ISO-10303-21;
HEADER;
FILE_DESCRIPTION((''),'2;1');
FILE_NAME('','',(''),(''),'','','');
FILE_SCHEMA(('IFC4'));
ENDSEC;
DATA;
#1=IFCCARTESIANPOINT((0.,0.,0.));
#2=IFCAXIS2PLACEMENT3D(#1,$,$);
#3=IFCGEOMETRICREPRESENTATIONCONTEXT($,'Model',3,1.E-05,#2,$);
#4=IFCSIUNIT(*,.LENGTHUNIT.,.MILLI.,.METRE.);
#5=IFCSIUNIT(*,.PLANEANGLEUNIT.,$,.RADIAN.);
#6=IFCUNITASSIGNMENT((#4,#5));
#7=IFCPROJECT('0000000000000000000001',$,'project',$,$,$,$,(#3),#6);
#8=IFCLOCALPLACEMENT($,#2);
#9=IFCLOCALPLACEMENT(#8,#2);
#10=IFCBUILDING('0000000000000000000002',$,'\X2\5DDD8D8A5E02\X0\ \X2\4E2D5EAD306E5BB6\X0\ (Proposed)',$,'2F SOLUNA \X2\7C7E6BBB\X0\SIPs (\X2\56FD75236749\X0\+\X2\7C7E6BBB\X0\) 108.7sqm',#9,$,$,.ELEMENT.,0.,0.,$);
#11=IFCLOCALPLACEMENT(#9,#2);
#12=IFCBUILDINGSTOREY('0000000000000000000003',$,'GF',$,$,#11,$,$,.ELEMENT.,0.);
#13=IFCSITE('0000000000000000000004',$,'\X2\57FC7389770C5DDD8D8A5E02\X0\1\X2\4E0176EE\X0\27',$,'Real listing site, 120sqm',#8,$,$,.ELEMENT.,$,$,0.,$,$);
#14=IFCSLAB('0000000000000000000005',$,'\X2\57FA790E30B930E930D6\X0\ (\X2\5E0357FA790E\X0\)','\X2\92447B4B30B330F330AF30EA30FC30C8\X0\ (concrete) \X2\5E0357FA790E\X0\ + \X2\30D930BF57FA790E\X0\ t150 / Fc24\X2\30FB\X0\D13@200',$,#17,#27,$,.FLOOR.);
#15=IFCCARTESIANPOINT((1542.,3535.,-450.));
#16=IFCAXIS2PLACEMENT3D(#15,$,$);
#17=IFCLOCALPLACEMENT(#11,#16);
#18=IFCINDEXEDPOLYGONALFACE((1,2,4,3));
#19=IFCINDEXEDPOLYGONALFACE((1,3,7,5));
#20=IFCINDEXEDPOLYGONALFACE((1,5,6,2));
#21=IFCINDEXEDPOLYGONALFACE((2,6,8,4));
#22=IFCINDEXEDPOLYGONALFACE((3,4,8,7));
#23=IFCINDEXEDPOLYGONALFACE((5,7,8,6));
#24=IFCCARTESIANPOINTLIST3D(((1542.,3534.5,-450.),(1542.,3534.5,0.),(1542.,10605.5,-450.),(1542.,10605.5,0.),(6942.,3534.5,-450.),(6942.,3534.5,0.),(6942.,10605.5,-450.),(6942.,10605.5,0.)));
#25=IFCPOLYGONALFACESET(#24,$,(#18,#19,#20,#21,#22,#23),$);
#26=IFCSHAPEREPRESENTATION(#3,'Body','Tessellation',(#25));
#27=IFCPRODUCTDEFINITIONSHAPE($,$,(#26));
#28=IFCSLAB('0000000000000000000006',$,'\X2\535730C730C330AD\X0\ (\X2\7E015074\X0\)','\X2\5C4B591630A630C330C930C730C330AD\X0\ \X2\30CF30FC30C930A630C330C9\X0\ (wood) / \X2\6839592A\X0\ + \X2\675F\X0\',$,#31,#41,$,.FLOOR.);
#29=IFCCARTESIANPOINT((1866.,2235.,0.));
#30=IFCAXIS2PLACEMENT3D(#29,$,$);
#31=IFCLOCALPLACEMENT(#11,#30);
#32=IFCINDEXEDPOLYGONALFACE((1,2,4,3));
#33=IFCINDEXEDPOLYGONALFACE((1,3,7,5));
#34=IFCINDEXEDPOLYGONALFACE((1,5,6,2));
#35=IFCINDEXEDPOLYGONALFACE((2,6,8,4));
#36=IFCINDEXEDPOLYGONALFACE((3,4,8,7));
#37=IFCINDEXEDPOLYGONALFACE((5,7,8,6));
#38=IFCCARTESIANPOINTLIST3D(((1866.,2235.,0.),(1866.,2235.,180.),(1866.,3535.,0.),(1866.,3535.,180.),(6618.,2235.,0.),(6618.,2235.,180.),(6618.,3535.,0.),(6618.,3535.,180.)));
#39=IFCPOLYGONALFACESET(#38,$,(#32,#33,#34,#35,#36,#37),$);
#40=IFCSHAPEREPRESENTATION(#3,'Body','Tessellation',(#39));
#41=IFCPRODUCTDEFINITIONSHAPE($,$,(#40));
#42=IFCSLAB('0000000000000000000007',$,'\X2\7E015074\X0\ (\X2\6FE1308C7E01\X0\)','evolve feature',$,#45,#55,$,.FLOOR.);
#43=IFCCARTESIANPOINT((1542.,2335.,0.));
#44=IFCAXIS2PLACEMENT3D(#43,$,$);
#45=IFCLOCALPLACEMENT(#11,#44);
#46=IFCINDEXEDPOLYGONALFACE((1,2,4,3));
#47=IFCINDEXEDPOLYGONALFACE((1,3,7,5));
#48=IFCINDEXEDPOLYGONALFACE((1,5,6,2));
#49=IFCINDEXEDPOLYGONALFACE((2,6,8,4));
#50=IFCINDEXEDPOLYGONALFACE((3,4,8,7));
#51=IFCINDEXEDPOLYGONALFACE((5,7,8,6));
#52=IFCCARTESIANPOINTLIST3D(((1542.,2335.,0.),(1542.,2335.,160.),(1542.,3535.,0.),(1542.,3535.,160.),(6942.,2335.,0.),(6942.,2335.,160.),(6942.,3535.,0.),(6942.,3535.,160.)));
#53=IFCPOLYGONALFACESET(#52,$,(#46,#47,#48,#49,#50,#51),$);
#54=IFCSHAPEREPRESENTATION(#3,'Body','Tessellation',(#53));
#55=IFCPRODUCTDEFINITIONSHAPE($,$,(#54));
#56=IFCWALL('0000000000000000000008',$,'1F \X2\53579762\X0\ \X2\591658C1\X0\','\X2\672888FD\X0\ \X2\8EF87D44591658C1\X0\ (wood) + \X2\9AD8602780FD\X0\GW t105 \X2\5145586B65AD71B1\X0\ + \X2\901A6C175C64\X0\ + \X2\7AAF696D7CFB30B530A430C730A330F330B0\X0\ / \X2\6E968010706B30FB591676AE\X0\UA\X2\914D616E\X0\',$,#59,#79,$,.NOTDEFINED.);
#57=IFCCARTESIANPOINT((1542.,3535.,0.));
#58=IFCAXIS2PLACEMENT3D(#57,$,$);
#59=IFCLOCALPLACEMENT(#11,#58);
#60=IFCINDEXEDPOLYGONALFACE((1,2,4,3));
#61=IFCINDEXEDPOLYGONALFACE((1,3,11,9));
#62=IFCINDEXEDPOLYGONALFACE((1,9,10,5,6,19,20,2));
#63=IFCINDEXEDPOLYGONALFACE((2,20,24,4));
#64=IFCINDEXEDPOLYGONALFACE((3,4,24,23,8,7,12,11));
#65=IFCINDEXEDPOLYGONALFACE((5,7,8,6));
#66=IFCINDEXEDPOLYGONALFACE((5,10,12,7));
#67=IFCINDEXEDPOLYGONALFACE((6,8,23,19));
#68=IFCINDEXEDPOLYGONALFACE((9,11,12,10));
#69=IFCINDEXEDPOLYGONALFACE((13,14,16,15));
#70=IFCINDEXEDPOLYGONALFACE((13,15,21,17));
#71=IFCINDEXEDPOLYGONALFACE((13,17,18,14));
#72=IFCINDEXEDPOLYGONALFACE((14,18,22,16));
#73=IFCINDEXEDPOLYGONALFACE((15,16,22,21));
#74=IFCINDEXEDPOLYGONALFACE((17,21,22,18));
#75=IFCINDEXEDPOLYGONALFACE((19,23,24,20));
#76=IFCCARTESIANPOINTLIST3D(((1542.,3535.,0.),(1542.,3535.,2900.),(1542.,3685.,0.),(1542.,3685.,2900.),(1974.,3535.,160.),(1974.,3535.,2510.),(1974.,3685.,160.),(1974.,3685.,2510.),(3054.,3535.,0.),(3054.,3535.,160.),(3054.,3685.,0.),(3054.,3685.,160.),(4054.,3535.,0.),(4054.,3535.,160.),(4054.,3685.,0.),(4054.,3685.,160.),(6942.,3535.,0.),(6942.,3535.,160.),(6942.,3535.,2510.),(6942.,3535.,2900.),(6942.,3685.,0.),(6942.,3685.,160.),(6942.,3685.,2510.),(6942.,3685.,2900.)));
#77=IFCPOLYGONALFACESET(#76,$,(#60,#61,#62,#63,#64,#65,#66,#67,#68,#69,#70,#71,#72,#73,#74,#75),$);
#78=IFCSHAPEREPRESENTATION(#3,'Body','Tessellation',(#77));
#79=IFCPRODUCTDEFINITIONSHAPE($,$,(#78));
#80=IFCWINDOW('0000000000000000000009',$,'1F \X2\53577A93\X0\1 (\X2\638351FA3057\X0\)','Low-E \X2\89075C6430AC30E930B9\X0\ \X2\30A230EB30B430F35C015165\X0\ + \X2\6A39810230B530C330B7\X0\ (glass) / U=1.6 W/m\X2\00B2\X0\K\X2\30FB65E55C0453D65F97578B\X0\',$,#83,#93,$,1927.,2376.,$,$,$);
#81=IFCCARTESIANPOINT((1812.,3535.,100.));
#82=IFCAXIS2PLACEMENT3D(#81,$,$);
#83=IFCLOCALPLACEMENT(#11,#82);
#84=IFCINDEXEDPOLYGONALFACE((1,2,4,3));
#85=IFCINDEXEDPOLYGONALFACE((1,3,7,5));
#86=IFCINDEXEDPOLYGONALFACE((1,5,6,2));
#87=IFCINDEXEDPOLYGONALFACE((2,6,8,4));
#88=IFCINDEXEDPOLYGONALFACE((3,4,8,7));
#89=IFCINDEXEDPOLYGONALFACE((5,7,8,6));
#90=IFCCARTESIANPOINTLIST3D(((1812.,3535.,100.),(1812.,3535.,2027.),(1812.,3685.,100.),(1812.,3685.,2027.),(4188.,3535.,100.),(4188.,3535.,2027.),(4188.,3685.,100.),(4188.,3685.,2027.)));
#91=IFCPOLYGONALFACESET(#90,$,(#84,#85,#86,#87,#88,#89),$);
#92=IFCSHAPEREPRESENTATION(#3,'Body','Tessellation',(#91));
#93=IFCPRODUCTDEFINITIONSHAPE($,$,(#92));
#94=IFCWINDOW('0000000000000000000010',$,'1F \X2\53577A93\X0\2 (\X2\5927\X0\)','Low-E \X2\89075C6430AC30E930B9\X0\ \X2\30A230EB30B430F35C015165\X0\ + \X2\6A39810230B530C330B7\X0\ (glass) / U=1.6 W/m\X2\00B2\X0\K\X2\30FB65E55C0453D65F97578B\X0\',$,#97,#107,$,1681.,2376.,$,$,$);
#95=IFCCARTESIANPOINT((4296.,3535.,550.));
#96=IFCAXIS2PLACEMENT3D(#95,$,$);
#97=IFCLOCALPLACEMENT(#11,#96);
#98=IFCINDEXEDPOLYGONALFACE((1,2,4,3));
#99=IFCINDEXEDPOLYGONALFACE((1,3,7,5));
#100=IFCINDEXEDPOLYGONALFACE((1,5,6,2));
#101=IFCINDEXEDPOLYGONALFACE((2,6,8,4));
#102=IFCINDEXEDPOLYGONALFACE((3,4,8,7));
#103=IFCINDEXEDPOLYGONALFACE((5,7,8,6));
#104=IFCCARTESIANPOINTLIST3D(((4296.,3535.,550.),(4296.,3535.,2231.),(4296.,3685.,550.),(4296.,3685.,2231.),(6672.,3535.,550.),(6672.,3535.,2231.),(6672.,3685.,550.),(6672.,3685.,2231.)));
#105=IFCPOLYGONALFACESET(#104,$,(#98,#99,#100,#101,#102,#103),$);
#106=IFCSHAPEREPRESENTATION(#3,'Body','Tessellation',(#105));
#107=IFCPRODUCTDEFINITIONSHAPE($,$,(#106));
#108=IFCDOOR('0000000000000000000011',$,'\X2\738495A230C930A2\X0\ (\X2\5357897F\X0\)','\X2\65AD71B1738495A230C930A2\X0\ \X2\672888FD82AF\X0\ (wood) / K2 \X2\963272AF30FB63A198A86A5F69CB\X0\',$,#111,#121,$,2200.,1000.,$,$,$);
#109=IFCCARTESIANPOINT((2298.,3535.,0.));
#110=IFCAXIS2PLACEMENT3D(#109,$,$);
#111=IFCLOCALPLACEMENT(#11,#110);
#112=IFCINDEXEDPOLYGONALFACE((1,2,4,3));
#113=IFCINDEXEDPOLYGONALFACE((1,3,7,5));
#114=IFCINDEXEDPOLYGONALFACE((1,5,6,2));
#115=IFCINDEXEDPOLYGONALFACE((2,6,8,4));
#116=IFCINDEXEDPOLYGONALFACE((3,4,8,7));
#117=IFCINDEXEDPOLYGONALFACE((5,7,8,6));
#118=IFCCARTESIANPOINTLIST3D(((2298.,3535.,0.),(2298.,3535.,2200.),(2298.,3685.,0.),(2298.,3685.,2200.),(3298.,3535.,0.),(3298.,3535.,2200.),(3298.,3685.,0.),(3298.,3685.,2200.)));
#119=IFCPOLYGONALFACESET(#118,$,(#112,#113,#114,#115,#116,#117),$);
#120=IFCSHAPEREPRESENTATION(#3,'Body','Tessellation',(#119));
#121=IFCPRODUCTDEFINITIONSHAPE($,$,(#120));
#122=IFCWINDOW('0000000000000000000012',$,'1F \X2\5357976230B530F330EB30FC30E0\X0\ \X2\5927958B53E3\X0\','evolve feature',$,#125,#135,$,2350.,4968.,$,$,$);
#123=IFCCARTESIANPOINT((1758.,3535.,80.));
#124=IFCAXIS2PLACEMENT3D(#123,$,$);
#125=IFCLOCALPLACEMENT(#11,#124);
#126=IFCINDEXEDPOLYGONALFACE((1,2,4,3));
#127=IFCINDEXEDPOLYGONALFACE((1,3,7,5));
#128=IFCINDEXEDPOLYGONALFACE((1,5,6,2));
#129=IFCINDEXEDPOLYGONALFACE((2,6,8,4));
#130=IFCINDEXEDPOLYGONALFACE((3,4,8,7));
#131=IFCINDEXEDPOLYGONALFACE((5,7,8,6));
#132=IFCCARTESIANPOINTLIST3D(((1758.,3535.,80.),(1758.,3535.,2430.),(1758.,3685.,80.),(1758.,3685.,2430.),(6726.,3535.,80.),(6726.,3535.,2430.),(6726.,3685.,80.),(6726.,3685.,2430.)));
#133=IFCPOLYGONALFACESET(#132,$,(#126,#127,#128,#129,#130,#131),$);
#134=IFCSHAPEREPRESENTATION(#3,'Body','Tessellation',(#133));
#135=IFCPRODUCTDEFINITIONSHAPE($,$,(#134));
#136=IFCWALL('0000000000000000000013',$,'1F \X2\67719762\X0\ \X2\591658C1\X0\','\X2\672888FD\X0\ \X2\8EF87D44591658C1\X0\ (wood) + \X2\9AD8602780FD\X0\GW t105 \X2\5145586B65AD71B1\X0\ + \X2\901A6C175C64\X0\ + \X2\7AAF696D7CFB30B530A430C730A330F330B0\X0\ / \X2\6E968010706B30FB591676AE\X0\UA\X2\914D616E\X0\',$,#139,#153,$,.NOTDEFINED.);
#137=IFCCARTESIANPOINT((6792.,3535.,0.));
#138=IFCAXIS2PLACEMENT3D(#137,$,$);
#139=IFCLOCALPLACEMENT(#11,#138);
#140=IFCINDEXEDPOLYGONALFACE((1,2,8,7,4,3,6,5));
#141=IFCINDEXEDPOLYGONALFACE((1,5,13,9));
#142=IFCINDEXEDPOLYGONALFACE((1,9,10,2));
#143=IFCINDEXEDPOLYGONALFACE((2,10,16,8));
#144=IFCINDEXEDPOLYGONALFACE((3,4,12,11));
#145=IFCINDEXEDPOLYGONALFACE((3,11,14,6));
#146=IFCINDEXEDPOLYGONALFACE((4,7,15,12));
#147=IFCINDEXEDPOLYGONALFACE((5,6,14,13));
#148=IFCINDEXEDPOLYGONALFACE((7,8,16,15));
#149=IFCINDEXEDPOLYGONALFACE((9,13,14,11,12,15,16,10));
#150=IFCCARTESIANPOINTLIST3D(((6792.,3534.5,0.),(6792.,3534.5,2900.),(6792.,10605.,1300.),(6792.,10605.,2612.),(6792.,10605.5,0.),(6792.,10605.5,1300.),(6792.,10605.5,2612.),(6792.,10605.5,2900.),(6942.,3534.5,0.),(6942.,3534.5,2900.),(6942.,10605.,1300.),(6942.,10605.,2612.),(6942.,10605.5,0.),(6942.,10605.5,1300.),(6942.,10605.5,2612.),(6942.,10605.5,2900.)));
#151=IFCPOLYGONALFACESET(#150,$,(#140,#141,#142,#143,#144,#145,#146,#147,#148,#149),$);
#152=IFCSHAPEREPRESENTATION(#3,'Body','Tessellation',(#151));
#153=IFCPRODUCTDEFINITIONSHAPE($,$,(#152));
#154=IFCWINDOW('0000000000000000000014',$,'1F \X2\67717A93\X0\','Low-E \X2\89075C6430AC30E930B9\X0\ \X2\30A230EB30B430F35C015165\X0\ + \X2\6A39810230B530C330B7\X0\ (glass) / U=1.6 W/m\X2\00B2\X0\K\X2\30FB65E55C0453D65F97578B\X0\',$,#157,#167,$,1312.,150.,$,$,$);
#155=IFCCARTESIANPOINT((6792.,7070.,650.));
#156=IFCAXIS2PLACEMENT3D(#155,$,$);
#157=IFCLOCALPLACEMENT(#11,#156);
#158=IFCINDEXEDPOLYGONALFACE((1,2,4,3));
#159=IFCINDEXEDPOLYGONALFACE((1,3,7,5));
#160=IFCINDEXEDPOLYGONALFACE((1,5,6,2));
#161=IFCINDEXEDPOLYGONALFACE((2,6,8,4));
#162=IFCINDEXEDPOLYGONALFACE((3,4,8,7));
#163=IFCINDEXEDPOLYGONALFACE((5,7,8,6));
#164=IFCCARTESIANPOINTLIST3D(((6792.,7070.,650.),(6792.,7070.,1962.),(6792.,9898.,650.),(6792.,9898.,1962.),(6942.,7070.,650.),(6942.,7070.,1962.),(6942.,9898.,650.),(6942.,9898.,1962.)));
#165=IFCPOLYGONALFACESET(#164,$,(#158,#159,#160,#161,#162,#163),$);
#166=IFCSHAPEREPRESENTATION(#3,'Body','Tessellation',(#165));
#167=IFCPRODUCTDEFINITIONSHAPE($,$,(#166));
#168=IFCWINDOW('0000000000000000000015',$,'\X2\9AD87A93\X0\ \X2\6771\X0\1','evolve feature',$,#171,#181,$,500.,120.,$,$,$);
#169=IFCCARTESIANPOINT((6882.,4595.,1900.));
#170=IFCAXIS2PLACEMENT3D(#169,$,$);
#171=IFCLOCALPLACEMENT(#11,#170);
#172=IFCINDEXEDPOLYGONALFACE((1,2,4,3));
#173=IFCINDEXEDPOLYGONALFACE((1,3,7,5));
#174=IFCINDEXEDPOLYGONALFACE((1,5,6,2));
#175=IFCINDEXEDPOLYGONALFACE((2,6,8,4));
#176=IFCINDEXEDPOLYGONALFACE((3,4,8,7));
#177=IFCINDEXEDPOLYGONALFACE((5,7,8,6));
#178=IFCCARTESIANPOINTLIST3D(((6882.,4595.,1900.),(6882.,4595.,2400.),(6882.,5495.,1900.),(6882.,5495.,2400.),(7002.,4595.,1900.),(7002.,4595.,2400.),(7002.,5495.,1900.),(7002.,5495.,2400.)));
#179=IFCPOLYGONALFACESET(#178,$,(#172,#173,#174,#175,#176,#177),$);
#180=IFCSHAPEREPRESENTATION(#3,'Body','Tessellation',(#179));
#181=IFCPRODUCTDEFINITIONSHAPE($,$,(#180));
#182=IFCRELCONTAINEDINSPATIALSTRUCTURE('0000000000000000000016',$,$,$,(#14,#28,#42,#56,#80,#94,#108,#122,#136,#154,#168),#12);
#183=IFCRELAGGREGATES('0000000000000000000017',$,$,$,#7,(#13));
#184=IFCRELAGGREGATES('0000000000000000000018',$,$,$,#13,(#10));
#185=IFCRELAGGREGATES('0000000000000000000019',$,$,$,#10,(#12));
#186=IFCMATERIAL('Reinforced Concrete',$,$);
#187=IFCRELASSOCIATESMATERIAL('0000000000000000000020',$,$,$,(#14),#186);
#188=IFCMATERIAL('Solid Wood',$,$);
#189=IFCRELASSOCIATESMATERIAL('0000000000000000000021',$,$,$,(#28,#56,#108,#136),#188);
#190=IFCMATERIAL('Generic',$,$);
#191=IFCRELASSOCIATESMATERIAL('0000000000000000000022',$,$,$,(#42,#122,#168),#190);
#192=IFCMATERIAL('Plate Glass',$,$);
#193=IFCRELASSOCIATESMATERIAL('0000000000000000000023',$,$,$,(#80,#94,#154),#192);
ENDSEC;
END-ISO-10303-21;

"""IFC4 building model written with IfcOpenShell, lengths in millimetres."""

from ifc_helpers import new_model, si_unit, frame, frame_2d, origin, place, context, project, spatial, rectangle, extrude, material, element, fill, save


model = new_model("IFC4")

# Units and contexts
model_context = context("Model", 3, precision=1e-05, world=origin())
ifc_project = project(units=[si_unit("LENGTHUNIT", "METRE", prefix="MILLI"), si_unit("PLANEANGLEUNIT", "RADIAN")], contexts=[model_context])

# Site, building, storey
site_placement = place(None, origin())
site = spatial("IfcSite", under=ifc_project, at=site_placement, Name="埼玉県川越市1丁目27", ObjectType="Real listing site, 120sqm", CompositionType="ELEMENT", RefElevation=0.0)
building_placement = place(site_placement, origin())
building = spatial("IfcBuilding", under=site, at=building_placement, Name="川越市 中庭の家 (Proposed)", ObjectType="2F SOLUNA 籾殻SIPs (国産杉+籾殻) 108.7sqm", CompositionType="ELEMENT", ElevationOfRefHeight=0.0, ElevationOfTerrain=0.0)
storey_placement = place(building_placement, origin())
storey = spatial("IfcBuildingStorey", under=building, at=storey_placement, Name="GF", CompositionType="ELEMENT", Elevation=0.0)

# Slabs
ifc_material_1 = material(Name="Reinforced Concrete")
slab_1_placement = place(storey_placement, frame((1542.0, 3535.0, -450.0)))
element("IfcSlab", 1, at=slab_1_placement, inside=storey, material=ifc_material_1, Name="基礎スラブ (布基礎)", Description="鉄筋コンクリート (concrete) 布基礎 + ベタ基礎 t150 / Fc24・D13@200", PredefinedType="FLOOR", context=model_context, shape_type="SweptSolid", body=[
    extrude(rectangle(XDim=5400.0, YDim=7071.0, at=frame_2d((2700.0, 3535.0))), frame((1542.0, 3535.0, -450.0)), (0.0, 0.0, 1.0), 450.0),
])
ifc_material_2 = material(Name="Solid Wood")
slab_2_placement = place(storey_placement, frame((1866.0, 2235.0, 0.0)))
element("IfcSlab", 2, at=slab_2_placement, inside=storey, material=ifc_material_2, Name="南デッキ (縁側)", Description="屋外ウッドデッキ ハードウッド (wood) / 根太 + 束", PredefinedType="FLOOR", context=model_context, shape_type="SweptSolid", body=[
    extrude(rectangle(XDim=4752.0, YDim=1300.0, at=frame_2d((2376.0, 650.0))), frame((1866.0, 2235.0, 0.0)), (0.0, 0.0, 1.0), 180.0),
])
ifc_material_3 = material(Name="Generic")
slab_3_placement = place(storey_placement, frame((1542.0, 2335.0, 0.0)))
element("IfcSlab", 3, at=slab_3_placement, inside=storey, material=ifc_material_3, Name="縁側 (濡れ縁)", Description="evolve feature", PredefinedType="FLOOR", context=model_context, shape_type="SweptSolid", body=[
    extrude(rectangle(XDim=5400.0, YDim=1200.0, at=frame_2d((2700.0, 600.0))), frame((1542.0, 2335.0, 0.0)), (0.0, 0.0, 1.0), 160.0),
])

# Wall, openings, windows, door
wall_1_placement = place(storey_placement, frame((1542.0, 3535.0, 0.0)))
wall_1 = element("IfcWall", 4, at=wall_1_placement, inside=storey, material=ifc_material_2, Name="1F 南面 外壁", Description="木製 軸組外壁 (wood) + 高性能GW t105 充填断熱 + 通気層 + 窯業系サイディング / 準耐火・外皮UA配慮", PredefinedType="NOTDEFINED", context=model_context, shape_type="SweptSolid", body=[
    extrude(rectangle(XDim=5400.0, YDim=150.0, at=frame_2d((2700.0, 75.0))), frame((1542.0, 3535.0, 0.0)), (0.0, 0.0, 1.0), 2900.0),
])
opening_1_placement = place(storey_placement, frame((1812.0, 3535.0, 100.0)))
opening_1 = element("IfcOpeningElement", 5, at=opening_1_placement, cuts=wall_1, PredefinedType="NOTDEFINED", context=model_context, shape_type="SweptSolid", body=[
    extrude(rectangle(XDim=2376.0, YDim=150.0, at=frame_2d((1188.0, 75.0))), frame((1812.0, 3535.0, 100.0)), (0.0, 0.0, 1.0), 1927.0),
])
opening_2_placement = place(storey_placement, frame((4296.0, 3535.0, 550.0)))
opening_2 = element("IfcOpeningElement", 6, at=opening_2_placement, cuts=wall_1, PredefinedType="NOTDEFINED", context=model_context, shape_type="SweptSolid", body=[
    extrude(rectangle(XDim=2376.0, YDim=150.0, at=frame_2d((1188.0, 75.0))), frame((4296.0, 3535.0, 550.0)), (0.0, 0.0, 1.0), 1681.0),
])
opening_3_placement = place(storey_placement, frame((2298.0, 3535.0, 0.0)))
opening_3 = element("IfcOpeningElement", 7, at=opening_3_placement, cuts=wall_1, PredefinedType="NOTDEFINED", context=model_context, shape_type="SweptSolid", body=[
    extrude(rectangle(XDim=1000.0, YDim=150.0, at=frame_2d((500.0, 75.0))), frame((2298.0, 3535.0, 0.0)), (0.0, 0.0, 1.0), 2200.0),
])
opening_4_placement = place(storey_placement, frame((1758.0, 3535.0, 80.0)))
opening_4 = element("IfcOpeningElement", 8, at=opening_4_placement, cuts=wall_1, PredefinedType="NOTDEFINED", context=model_context, shape_type="SweptSolid", body=[
    extrude(rectangle(XDim=4968.0, YDim=150.0, at=frame_2d((2484.0, 75.0))), frame((1758.0, 3535.0, 80.0)), (0.0, 0.0, 1.0), 2350.0),
])
ifc_material_4 = material(Name="Plate Glass")
window_1_placement = place(storey_placement, frame((1812.0, 3535.0, 100.0)))
window_1 = element("IfcWindow", 9, at=window_1_placement, inside=storey, material=ifc_material_4, Name="1F 南窓1 (掃出し)", Description="Low-E 複層ガラス アルゴン封入 + 樹脂サッシ (glass) / U=1.6 W/m²K・日射取得型", OverallHeight=1927.0, OverallWidth=2376.0, context=model_context, shape_type="SweptSolid", body=[
    extrude(rectangle(XDim=2376.0, YDim=150.0, at=frame_2d((1188.0, 75.0))), frame((1812.0, 3535.0, 100.0)), (0.0, 0.0, 1.0), 1927.0),
])
fill(opening_1, window_1)
window_2_placement = place(storey_placement, frame((4296.0, 3535.0, 550.0)))
window_2 = element("IfcWindow", 10, at=window_2_placement, inside=storey, material=ifc_material_4, Name="1F 南窓2 (大)", Description="Low-E 複層ガラス アルゴン封入 + 樹脂サッシ (glass) / U=1.6 W/m²K・日射取得型", OverallHeight=1681.0, OverallWidth=2376.0, context=model_context, shape_type="SweptSolid", body=[
    extrude(rectangle(XDim=2376.0, YDim=150.0, at=frame_2d((1188.0, 75.0))), frame((4296.0, 3535.0, 550.0)), (0.0, 0.0, 1.0), 1681.0),
])
fill(opening_2, window_2)
door_placement = place(storey_placement, frame((2298.0, 3535.0, 0.0)))
door = element("IfcDoor", 11, at=door_placement, inside=storey, material=ifc_material_2, Name="玄関ドア (南西)", Description="断熱玄関ドア 木製芯 (wood) / K2 防犯・採風機構", OverallHeight=2200.0, OverallWidth=1000.0, context=model_context, shape_type="SweptSolid", body=[
    extrude(rectangle(XDim=1000.0, YDim=150.0, at=frame_2d((500.0, 75.0))), frame((2298.0, 3535.0, 0.0)), (0.0, 0.0, 1.0), 2200.0),
])
fill(opening_3, door)
window_3_placement = place(storey_placement, frame((1758.0, 3535.0, 80.0)))
window_3 = element("IfcWindow", 12, at=window_3_placement, inside=storey, material=ifc_material_3, Name="1F 南面サンルーム 大開口", Description="evolve feature", OverallHeight=2350.0, OverallWidth=4968.0, context=model_context, shape_type="SweptSolid", body=[
    extrude(rectangle(XDim=4968.0, YDim=150.0, at=frame_2d((2484.0, 75.0))), frame((1758.0, 3535.0, 80.0)), (0.0, 0.0, 1.0), 2350.0),
])
fill(opening_4, window_3)

# Wall, openings, windows
wall_2_placement = place(storey_placement, frame((6792.0, 3535.0, 0.0)))
wall_2 = element("IfcWall", 13, at=wall_2_placement, inside=storey, material=ifc_material_2, Name="1F 東面 外壁", Description="木製 軸組外壁 (wood) + 高性能GW t105 充填断熱 + 通気層 + 窯業系サイディング / 準耐火・外皮UA配慮", PredefinedType="NOTDEFINED", context=model_context, shape_type="SweptSolid", body=[
    extrude(rectangle(XDim=150.0, YDim=7071.0, at=frame_2d((75.0, 3535.0))), frame((6792.0, 3535.0, 0.0)), (0.0, 0.0, 1.0), 2900.0),
])
opening_5_placement = place(storey_placement, frame((6792.0, 7070.0, 650.0)))
opening_5 = element("IfcOpeningElement", 14, at=opening_5_placement, cuts=wall_2, PredefinedType="NOTDEFINED", context=model_context, shape_type="SweptSolid", body=[
    extrude(rectangle(XDim=150.0, YDim=2828.0, at=frame_2d((75.0, 1414.0))), frame((6792.0, 7070.0, 650.0)), (0.0, 0.0, 1.0), 1312.0),
])
opening_6_placement = place(storey_placement, frame((6882.0, 4595.0, 1900.0)))
opening_6 = element("IfcOpeningElement", 15, at=opening_6_placement, cuts=wall_2, PredefinedType="NOTDEFINED", context=model_context, shape_type="SweptSolid", body=[
    extrude(rectangle(XDim=120.0, YDim=900.0, at=frame_2d((60.0, 450.0))), frame((6882.0, 4595.0, 1900.0)), (0.0, 0.0, 1.0), 500.0),
])
window_4_placement = place(storey_placement, frame((6792.0, 7070.0, 650.0)))
window_4 = element("IfcWindow", 16, at=window_4_placement, inside=storey, material=ifc_material_4, Name="1F 東窓", Description="Low-E 複層ガラス アルゴン封入 + 樹脂サッシ (glass) / U=1.6 W/m²K・日射取得型", OverallHeight=1312.0, OverallWidth=150.0, context=model_context, shape_type="SweptSolid", body=[
    extrude(rectangle(XDim=150.0, YDim=2828.0, at=frame_2d((75.0, 1414.0))), frame((6792.0, 7070.0, 650.0)), (0.0, 0.0, 1.0), 1312.0),
])
fill(opening_5, window_4)
window_5_placement = place(storey_placement, frame((6882.0, 4595.0, 1900.0)))
window_5 = element("IfcWindow", 17, at=window_5_placement, inside=storey, material=ifc_material_3, Name="高窓 東1", Description="evolve feature", OverallHeight=500.0, OverallWidth=120.0, context=model_context, shape_type="SweptSolid", body=[
    extrude(rectangle(XDim=120.0, YDim=900.0, at=frame_2d((60.0, 450.0))), frame((6882.0, 4595.0, 1900.0)), (0.0, 0.0, 1.0), 500.0),
])
fill(opening_6, window_5)

save(model, "model.ifc")
